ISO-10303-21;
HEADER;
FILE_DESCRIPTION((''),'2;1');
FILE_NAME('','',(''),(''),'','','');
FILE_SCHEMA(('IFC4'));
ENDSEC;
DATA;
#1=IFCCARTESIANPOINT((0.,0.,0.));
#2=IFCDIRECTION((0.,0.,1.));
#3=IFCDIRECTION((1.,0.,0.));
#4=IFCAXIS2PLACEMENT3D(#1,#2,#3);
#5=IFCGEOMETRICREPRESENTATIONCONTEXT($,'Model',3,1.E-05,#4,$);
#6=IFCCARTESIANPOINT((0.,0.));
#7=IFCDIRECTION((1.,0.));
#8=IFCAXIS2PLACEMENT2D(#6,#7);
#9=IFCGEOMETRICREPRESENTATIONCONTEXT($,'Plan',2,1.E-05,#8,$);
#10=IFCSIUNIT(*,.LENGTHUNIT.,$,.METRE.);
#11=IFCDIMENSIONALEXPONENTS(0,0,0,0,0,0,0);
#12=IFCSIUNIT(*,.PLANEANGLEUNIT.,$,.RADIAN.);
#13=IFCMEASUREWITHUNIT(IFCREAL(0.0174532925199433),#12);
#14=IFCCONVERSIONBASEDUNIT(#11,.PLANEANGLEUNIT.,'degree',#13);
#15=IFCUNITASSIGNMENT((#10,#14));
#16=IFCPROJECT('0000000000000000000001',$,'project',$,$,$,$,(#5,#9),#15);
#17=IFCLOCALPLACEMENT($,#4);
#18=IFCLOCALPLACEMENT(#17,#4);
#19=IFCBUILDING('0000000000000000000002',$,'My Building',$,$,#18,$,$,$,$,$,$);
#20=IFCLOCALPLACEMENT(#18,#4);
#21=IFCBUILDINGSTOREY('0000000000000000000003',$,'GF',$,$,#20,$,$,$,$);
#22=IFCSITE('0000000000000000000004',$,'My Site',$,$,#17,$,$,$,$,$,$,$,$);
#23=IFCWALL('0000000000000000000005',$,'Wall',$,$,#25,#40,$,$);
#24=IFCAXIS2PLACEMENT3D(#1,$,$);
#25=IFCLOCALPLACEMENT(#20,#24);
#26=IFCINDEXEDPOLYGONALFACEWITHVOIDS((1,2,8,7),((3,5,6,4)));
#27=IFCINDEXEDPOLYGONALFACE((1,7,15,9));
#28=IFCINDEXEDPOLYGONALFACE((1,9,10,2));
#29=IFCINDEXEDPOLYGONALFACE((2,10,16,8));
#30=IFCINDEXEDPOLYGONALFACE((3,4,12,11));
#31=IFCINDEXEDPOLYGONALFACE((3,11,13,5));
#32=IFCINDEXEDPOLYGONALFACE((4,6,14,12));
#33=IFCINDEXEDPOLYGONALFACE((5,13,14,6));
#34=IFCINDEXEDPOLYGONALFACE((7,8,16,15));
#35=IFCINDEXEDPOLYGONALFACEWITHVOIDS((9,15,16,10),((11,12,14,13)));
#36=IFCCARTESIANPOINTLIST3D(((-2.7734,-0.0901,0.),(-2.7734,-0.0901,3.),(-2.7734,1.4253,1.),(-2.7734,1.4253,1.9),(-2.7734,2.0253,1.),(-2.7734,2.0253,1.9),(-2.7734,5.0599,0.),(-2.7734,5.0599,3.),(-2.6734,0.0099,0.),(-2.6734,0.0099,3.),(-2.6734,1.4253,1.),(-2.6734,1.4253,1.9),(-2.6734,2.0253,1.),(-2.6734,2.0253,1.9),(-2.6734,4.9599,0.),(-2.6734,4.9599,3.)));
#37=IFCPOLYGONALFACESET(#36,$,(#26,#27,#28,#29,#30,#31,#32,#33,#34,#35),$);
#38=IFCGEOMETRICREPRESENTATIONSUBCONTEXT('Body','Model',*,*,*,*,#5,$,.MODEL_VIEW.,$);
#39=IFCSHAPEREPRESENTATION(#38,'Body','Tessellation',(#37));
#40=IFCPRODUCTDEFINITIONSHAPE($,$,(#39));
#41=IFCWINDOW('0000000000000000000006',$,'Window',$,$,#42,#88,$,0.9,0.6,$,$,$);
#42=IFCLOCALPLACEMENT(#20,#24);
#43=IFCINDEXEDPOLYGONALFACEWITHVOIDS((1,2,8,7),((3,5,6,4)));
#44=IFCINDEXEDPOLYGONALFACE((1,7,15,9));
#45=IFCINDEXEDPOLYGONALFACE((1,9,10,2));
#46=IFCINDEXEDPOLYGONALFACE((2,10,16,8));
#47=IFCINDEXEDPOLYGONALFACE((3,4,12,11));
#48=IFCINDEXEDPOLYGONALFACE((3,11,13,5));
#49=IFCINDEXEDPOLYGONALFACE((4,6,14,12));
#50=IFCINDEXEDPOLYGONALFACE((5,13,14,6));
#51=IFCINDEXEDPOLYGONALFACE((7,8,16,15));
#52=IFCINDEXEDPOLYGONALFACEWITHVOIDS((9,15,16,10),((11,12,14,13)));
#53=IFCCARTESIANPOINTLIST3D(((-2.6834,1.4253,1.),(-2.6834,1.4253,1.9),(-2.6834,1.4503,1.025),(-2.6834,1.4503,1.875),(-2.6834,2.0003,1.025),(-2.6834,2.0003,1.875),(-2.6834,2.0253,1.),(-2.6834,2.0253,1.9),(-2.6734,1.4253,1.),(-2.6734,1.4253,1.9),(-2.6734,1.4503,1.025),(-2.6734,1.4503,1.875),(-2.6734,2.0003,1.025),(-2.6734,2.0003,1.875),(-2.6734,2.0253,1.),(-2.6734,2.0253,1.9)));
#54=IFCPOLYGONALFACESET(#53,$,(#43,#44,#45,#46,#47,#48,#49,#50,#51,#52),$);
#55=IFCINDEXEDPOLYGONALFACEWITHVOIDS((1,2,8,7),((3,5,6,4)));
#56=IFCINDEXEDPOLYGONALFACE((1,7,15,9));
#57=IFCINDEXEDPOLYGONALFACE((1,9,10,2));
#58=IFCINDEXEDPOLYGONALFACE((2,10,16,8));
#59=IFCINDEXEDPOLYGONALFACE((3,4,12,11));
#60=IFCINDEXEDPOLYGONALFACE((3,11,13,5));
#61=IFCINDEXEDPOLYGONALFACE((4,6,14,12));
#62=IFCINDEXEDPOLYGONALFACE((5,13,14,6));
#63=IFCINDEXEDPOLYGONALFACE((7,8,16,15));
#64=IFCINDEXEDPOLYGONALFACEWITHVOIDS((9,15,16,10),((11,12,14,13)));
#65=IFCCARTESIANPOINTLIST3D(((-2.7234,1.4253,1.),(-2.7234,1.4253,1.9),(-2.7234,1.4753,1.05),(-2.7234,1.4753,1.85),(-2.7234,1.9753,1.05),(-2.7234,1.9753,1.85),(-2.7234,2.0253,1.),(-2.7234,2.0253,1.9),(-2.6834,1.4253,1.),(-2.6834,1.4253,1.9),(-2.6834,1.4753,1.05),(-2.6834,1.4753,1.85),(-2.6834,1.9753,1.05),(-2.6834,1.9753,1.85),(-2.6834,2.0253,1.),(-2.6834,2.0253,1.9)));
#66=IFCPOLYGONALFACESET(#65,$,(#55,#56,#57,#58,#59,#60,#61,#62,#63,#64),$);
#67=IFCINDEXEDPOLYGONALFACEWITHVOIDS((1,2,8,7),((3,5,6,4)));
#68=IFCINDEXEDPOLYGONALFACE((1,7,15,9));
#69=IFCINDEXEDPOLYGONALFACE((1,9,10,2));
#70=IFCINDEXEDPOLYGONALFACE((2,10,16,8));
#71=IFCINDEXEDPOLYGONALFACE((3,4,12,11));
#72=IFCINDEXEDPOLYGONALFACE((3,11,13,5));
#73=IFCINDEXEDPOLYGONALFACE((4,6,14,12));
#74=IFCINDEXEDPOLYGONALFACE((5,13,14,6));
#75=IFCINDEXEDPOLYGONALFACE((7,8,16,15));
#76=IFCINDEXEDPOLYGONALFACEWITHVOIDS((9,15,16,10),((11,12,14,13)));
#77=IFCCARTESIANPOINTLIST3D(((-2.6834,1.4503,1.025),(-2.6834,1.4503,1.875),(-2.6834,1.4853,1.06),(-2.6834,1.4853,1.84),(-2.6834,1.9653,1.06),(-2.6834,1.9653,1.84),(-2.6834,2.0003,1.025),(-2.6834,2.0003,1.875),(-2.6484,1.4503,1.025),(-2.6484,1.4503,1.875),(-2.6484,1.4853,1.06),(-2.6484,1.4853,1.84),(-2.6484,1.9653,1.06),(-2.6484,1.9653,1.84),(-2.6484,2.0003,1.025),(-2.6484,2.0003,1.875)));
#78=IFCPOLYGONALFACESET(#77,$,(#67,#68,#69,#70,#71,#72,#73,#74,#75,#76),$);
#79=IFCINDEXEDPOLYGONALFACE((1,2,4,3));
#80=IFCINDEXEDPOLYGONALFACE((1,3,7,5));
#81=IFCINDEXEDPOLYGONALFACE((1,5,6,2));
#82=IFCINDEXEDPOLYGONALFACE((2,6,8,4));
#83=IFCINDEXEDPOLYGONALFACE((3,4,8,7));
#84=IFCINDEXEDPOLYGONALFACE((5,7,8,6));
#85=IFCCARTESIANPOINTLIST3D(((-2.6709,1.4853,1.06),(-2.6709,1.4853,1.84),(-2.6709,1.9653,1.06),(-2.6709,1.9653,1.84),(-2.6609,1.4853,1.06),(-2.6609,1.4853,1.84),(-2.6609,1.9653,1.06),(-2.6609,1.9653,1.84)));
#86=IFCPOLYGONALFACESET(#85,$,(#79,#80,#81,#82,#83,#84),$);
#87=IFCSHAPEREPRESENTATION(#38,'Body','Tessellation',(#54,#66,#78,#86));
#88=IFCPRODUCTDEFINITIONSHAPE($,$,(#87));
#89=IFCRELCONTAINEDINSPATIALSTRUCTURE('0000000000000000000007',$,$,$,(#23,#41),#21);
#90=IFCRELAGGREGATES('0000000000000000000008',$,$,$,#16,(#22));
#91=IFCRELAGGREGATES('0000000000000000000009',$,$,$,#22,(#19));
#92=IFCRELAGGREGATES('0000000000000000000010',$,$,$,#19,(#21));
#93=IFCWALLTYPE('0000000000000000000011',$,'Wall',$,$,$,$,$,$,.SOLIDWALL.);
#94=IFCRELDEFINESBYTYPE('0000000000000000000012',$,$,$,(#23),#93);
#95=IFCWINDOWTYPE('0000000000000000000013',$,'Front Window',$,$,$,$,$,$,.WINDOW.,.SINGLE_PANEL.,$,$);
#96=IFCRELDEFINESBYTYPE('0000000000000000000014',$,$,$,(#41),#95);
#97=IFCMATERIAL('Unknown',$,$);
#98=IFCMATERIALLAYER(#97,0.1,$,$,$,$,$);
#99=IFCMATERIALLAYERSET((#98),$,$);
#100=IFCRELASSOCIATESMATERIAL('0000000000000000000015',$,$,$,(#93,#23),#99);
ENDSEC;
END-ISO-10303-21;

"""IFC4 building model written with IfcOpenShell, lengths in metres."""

from ifc_helpers import new_model, entity, si_unit, converted_unit, frame, origin_with_axes, origin_2d_with_axis, place, context, subcontext, project, spatial, line, indexed_curve, outline, extrude, shape, source, transform, mapped, material, layer, layer_set, layer_usage, type_object, type_shapes, element, fill, save


model = new_model("IFC4")

# Units and contexts
model_context = context("Model", 3, precision=1e-05, world=origin_with_axes())
plan_context = context("Plan", 2, precision=1e-05, world=origin_2d_with_axis())
body_context_1 = subcontext(model_context, "Body", "Model", "MODEL_VIEW")
body_context_2 = subcontext(plan_context, "Body", "Plan", "PLAN_VIEW")
ifc_project = project(units=[si_unit("LENGTHUNIT", "METRE"), converted_unit("PLANEANGLEUNIT", "degree", entity("IfcReal", 0.0174532925199433), si_unit("PLANEANGLEUNIT", "RADIAN"), dimensions=[0, 0, 0, 0, 0, 0, 0])], contexts=[model_context, plan_context])

# Site, building, storey
site_placement = place(None, origin_with_axes())
site = spatial("IfcSite", under=ifc_project, at=site_placement, Name="My Site")
building_placement = place(site_placement, origin_with_axes())
building = spatial("IfcBuilding", under=site, at=building_placement, Name="My Building")
storey_placement = place(building_placement, origin_with_axes())
storey = spatial("IfcBuildingStorey", under=building, at=storey_placement, Name="GF")

# Shared definitions
ifc_material_1 = material(Name="Unknown")

# Shared definitions
ifc_layer_1 = layer(ifc_material_1, 0.1)
ifc_layer_set_1 = layer_set([ifc_layer_1])
wall_type = type_object("IfcWallType", Name="Wall", PredefinedType="SOLIDWALL", material=ifc_layer_set_1)

# Wall, opening, window
ifc_layer_usage_1 = layer_usage(ifc_layer_set_1, "AXIS2", "POSITIVE", 0.0)
wall_1_placement = place(storey_placement, frame((-2.7734, 5.0599, 0.0), z_axis=(0.0, 0.0, 1.0), x_axis=(0.0, -1.0, 0.0)))
wall_1 = element("IfcWall", 1, at=wall_1_placement, inside=storey, type_object=wall_type, material=ifc_layer_usage_1, Name="Wall", context=body_context_1, shape_type="SweptSolid", body=[
    extrude(outline(indexed_curve([(0.0, 0.0), (0.1, 0.1), (5.05, 0.1), (5.15, 0.0)], segments=[line(1, 2, 3, 4, 1)])), origin_with_axes(), (0.0, 0.0, 1.0), 3.0),
])
shared_shape_1 = source(origin_with_axes(), body_context_1, "Body", "SweptSolid", [
    extrude(outline(indexed_curve([(0.0, 0.0), (0.6, 0.0), (0.6, 0.9), (0.0, 0.9)], segments=[line(1, 2, 3, 4, 1)])), frame((0.0, -0.6, 0.0), z_axis=(0.0, -1.0, 0.0), x_axis=(1.0, 0.0, 0.0)), (0.0, 0.0, -1.0), 1.2),
])
opening_1_placement = place(wall_1_placement, frame((3.0346, 0.0, 1.0), z_axis=(0.0, 0.0, 1.0), x_axis=(1.0, 0.0, 0.0)))
opening_1 = element("IfcOpeningElement", 2, at=opening_1_placement, cuts=wall_1, PredefinedType="OPENING", context=body_context_1, shape_type="MappedRepresentation", body=[
    mapped(shared_shape_1, transform((0.0, 0.0, 0.0), x_axis=(1.0, 0.0, 0.0), y_axis=(0.0, 1.0, 0.0), z_axis=(0.0, 0.0, 1.0), scale=1.0)),
])
window_type_1 = type_object("IfcWindowType", Name="Front Window", PartitioningType="SINGLE_PANEL", PredefinedType="WINDOW")
shared_shape_2 = source(origin_with_axes(), body_context_1, "Body", "SweptSolid", [
    extrude(outline(indexed_curve([(0.0, 0.0), (0.6, 0.0), (0.6, 0.9), (0.0, 0.9)], segments=[line(1, 2, 3, 4, 1)]), holes=[indexed_curve([(0.025, 0.025), (0.575, 0.025), (0.575, 0.875), (0.025, 0.875)], segments=[line(1, 2, 3, 4, 1)])]), frame((0.0, 0.09, 0.0), z_axis=(0.0, -1.0, 0.0), x_axis=(1.0, 0.0, 0.0)), (0.0, 0.0, -1.0), 0.01),
    extrude(outline(indexed_curve([(0.0, 0.0), (0.6, 0.0), (0.6, 0.9), (0.0, 0.9)], segments=[line(1, 2, 3, 4, 1)]), holes=[indexed_curve([(0.05, 0.05), (0.55, 0.05), (0.55, 0.85), (0.05, 0.85)], segments=[line(1, 2, 3, 4, 1)])]), frame((0.0, 0.05, 0.0), z_axis=(0.0, -1.0, 0.0), x_axis=(1.0, 0.0, 0.0)), (0.0, 0.0, -1.0), 0.04),
    extrude(outline(indexed_curve([(0.0, 0.0), (0.55, 0.0), (0.55, 0.85), (0.0, 0.85)], segments=[line(1, 2, 3, 4, 1)]), holes=[indexed_curve([(0.035, 0.035), (0.515, 0.035), (0.515, 0.815), (0.035, 0.815)], segments=[line(1, 2, 3, 4, 1)])]), frame((0.025, 0.09, 0.025), z_axis=(0.0, -1.0, 0.0), x_axis=(1.0, 0.0, 0.0)), (0.0, 0.0, -1.0), 0.035),
    extrude(outline(indexed_curve([(0.035, 0.035), (0.515, 0.035), (0.515, 0.815), (0.035, 0.815)], segments=[line(1, 2, 3, 4, 1)])), frame((0.025, 0.1025, 0.025), z_axis=(0.0, -1.0, 0.0), x_axis=(1.0, 0.0, 0.0)), (0.0, 0.0, -1.0), 0.01),
])
shared_shape_3 = source(origin_with_axes(), body_context_2, "Body", "Curve2D", [
    entity("IfcIndexedPolyCurve", entity("IfcCartesianPointList2D", [[0.05, 0.05], [0.55, 0.05]])),
    entity("IfcIndexedPolyCurve", entity("IfcCartesianPointList2D", [[0.0, 0.1], [0.025, 0.1], [0.025, 0.09], [0.05, 0.09], [0.05, 0.05], [0.0, 0.05]]), [entity("IfcLineIndex", [1, 2, 3, 4, 5, 6, 1])]),
    entity("IfcIndexedPolyCurve", entity("IfcCartesianPointList2D", [[0.6, 0.1], [0.575, 0.1], [0.575, 0.09], [0.55, 0.09], [0.55, 0.05], [0.6, 0.05]]), [entity("IfcLineIndex", [1, 2, 3, 4, 5, 6, 1])]),
    entity("IfcIndexedPolyCurve", entity("IfcCartesianPointList2D", [[0.025, 0.09], [0.06, 0.09], [0.06, 0.125], [0.025, 0.125]]), [entity("IfcLineIndex", [1, 2, 3, 4, 1])]),
    entity("IfcIndexedPolyCurve", entity("IfcCartesianPointList2D", [[0.575, 0.09], [0.54, 0.09], [0.54, 0.125], [0.575, 0.125]]), [entity("IfcLineIndex", [1, 2, 3, 4, 1])]),
    entity("IfcIndexedPolyCurve", entity("IfcCartesianPointList2D", [[0.06, 0.09], [0.54, 0.09]])),
    entity("IfcIndexedPolyCurve", entity("IfcCartesianPointList2D", [[0.06, 0.125], [0.54, 0.125]])),
    entity("IfcIndexedPolyCurve", entity("IfcCartesianPointList2D", [[0.06, 0.1075], [0.54, 0.1075]])),
])
type_shapes(window_type_1, [shared_shape_2, shared_shape_3])
window_1_placement = place(opening_1_placement, frame((0.0, 0.0, 0.0), z_axis=(0.0, 0.0, 1.0), x_axis=(1.0, 0.0, 0.0)))
window_1 = element("IfcWindow", 3, at=window_1_placement, inside=storey, type_object=window_type_1, Name="Window", OverallHeight=0.9, OverallWidth=0.6, shapes=[
    shape(body_context_1, "Body", "MappedRepresentation", [mapped(shared_shape_2, transform((0.0, 0.0, 0.0), x_axis=(1.0, 0.0, 0.0), y_axis=(0.0, 1.0, 0.0), z_axis=(0.0, 0.0, 1.0), scale=1.0))]),
    shape(body_context_2, "Body", "MappedRepresentation", [mapped(shared_shape_3, transform((0.0, 0.0, 0.0), x_axis=(1.0, 0.0, 0.0), y_axis=(0.0, 1.0, 0.0), z_axis=(0.0, 0.0, 1.0), scale=1.0))]),
])
fill(opening_1, window_1)

save(model, "model.ifc")
